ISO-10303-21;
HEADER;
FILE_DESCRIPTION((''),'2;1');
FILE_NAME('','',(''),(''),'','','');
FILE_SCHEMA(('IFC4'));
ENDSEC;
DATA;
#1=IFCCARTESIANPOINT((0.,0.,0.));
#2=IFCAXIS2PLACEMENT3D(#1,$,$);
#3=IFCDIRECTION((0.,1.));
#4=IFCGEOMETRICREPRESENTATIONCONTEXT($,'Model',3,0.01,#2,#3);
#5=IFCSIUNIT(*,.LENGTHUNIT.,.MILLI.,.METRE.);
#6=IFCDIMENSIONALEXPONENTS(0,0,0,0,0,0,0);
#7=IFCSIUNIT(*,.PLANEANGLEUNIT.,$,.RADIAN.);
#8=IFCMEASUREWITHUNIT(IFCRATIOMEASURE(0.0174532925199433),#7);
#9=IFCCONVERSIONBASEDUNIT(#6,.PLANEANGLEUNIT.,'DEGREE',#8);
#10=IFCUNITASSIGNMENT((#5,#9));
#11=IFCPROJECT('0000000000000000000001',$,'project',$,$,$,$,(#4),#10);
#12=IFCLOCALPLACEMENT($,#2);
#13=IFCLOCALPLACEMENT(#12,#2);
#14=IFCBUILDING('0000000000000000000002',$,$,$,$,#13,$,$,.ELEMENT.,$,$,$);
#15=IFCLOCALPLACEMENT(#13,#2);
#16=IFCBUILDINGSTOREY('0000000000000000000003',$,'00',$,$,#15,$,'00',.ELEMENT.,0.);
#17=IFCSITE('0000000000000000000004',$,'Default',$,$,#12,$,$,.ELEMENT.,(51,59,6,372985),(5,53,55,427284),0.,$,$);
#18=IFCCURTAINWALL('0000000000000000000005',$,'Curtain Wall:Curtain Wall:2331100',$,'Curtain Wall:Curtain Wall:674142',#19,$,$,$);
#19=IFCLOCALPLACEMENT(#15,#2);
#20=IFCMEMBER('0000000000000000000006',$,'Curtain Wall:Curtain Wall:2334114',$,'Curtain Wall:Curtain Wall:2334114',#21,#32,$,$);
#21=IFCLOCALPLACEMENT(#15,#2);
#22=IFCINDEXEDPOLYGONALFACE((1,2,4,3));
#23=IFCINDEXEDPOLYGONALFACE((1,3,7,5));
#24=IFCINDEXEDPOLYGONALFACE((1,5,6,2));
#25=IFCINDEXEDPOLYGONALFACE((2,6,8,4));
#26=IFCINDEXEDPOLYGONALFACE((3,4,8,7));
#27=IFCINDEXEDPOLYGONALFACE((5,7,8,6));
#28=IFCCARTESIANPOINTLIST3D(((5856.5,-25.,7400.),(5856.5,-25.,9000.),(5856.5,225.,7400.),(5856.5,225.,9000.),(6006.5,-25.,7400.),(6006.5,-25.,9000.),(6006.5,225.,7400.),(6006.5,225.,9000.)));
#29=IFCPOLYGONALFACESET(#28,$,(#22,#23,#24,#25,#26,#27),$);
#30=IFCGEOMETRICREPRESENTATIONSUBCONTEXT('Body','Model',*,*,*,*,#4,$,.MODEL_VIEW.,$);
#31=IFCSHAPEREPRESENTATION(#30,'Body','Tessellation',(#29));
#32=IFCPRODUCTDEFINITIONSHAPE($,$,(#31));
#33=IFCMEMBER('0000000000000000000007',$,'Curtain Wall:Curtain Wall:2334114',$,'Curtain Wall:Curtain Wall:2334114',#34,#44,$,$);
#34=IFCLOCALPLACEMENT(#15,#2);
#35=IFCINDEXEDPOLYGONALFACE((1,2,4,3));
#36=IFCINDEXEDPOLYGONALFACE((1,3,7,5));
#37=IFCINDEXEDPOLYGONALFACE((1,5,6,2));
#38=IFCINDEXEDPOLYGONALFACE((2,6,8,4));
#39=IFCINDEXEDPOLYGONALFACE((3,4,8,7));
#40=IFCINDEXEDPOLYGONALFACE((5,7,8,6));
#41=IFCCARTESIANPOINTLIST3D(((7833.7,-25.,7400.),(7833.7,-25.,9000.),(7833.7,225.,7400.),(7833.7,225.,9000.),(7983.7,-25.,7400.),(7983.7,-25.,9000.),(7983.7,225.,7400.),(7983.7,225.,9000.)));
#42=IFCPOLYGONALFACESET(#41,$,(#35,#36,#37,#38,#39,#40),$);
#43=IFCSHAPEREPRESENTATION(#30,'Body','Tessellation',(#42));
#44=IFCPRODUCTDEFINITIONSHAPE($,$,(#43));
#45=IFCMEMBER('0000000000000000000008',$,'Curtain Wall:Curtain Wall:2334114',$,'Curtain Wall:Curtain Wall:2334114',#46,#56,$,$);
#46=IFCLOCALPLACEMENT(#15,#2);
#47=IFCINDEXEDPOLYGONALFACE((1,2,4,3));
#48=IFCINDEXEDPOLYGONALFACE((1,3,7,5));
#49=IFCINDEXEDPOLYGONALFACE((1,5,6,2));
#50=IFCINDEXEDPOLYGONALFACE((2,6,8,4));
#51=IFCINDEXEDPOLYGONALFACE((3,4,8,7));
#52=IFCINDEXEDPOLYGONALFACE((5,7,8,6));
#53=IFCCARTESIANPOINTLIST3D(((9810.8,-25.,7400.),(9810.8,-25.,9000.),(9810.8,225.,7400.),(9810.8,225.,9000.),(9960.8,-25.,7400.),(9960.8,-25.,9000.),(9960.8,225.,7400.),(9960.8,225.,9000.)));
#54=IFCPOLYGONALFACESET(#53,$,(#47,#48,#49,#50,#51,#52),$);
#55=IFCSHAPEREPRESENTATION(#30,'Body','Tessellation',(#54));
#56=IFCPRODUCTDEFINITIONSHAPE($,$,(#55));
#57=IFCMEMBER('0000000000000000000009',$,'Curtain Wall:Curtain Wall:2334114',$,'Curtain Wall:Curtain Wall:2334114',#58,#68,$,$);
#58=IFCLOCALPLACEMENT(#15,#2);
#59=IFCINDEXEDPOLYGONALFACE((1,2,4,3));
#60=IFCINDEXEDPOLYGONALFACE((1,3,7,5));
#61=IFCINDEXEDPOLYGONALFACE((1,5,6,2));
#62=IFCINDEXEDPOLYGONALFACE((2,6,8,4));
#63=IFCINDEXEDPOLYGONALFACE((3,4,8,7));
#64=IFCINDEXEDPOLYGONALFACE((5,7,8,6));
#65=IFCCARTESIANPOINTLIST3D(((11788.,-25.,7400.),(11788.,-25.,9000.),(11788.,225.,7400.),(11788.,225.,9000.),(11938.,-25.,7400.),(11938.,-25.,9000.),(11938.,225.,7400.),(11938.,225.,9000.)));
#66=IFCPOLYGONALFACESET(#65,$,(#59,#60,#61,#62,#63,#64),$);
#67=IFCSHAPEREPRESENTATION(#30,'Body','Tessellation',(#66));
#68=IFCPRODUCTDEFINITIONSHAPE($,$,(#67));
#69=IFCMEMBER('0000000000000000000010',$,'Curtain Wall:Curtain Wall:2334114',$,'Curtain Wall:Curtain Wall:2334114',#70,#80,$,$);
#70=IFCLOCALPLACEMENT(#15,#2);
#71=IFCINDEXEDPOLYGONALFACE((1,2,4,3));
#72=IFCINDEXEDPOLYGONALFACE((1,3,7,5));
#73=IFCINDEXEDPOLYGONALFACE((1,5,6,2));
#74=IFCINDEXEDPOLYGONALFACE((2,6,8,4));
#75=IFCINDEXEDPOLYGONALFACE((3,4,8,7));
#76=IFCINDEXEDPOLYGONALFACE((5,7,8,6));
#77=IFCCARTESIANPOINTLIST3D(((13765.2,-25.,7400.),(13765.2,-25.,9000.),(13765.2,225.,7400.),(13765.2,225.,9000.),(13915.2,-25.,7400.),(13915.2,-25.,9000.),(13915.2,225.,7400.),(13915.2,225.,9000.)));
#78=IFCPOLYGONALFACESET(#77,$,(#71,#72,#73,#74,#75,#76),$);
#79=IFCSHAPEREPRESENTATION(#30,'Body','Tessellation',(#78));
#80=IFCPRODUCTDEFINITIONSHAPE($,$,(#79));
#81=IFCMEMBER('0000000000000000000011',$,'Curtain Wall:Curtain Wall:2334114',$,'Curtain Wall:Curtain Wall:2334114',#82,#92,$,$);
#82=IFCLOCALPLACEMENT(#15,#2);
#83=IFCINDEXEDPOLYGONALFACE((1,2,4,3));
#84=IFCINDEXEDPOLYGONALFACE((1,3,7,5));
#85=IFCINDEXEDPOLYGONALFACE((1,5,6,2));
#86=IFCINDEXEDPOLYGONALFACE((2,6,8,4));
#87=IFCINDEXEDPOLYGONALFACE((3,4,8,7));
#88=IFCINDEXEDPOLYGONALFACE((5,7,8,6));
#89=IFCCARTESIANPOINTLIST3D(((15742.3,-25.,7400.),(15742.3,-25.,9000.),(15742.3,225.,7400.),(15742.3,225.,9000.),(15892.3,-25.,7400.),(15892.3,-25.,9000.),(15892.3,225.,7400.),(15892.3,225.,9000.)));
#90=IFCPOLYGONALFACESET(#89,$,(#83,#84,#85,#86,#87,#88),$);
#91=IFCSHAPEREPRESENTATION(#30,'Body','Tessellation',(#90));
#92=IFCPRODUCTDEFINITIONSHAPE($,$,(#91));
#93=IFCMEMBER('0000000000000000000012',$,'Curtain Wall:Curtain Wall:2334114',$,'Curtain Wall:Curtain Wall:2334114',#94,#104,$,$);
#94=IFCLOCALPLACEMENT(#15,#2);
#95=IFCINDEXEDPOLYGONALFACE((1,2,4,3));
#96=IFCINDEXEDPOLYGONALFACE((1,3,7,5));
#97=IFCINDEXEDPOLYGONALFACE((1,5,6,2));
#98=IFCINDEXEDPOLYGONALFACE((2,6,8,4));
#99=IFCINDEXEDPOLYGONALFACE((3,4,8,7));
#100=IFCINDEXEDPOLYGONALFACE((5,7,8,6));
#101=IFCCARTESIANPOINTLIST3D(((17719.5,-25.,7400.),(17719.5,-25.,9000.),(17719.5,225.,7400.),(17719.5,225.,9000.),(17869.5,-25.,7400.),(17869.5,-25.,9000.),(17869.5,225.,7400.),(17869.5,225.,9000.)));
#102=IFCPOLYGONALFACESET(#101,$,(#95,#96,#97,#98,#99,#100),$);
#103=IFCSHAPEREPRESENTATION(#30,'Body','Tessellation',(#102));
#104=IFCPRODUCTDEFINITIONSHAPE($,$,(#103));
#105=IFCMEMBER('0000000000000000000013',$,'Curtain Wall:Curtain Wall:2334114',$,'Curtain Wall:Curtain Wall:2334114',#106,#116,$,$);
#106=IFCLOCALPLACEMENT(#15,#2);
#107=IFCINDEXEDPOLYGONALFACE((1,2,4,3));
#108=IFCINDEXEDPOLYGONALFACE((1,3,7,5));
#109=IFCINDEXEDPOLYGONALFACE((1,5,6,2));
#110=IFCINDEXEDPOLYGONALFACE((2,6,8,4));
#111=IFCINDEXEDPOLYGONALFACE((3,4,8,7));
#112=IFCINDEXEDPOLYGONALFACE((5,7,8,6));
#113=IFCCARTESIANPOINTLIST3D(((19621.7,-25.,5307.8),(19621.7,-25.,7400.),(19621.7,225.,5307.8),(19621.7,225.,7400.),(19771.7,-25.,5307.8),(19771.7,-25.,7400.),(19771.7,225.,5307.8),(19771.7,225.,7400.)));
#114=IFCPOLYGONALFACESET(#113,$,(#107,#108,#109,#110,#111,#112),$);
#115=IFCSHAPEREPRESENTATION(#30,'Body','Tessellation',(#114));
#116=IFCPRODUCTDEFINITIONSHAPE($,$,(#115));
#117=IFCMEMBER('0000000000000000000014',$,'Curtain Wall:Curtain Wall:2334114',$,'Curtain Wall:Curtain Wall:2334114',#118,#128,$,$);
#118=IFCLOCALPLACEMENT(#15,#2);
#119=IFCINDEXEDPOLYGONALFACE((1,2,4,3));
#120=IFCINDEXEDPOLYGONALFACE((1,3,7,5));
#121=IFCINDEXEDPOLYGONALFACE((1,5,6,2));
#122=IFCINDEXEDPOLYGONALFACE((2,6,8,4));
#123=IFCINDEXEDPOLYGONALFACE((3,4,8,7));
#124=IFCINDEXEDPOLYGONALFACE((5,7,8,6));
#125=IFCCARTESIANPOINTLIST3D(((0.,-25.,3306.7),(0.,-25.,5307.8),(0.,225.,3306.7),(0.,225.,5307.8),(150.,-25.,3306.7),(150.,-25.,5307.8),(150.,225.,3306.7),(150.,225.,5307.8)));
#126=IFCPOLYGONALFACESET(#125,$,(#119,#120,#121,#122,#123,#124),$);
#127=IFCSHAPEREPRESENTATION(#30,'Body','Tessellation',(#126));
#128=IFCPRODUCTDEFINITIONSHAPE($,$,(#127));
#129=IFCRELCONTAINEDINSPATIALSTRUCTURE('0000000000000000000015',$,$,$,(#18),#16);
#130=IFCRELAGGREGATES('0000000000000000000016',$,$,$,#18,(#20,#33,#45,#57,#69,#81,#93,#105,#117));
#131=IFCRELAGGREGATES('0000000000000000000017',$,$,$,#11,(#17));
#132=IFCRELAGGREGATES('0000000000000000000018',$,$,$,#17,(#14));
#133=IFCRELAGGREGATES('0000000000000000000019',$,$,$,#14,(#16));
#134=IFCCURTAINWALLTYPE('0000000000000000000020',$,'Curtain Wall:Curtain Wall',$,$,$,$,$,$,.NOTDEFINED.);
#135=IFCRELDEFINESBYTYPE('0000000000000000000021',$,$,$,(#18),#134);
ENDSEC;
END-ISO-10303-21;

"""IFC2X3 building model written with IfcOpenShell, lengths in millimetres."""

from ifc_helpers import new_model, entity, si_unit, converted_unit, direction, frame, frame_2d, origin, origin_2d_with_axis, place, context, subcontext, project, spatial, rectangle, extrude, type_object, element, aggregate, save


model = new_model("IFC2X3")

# Units and contexts
model_context = context("Model", 3, precision=0.01, world=origin(), true_north=direction((0.0, 1.0)))
body_context = subcontext(model_context, "Body", "Model", "MODEL_VIEW")
ifc_project = project(units=[si_unit("LENGTHUNIT", "METRE", prefix="MILLI"), converted_unit("PLANEANGLEUNIT", "DEGREE", entity("IfcRatioMeasure", 0.0174532925199433), si_unit("PLANEANGLEUNIT", "RADIAN"), dimensions=[0, 0, 0, 0, 0, 0, 0])], contexts=[model_context])

# Site, building, storey
site_placement = place(None, origin())
site = spatial("IfcSite", under=ifc_project, at=site_placement, Name="Default", CompositionType="ELEMENT", RefLatitude=(51, 59, 6, 372985), RefLongitude=(5, 53, 55, 427284), RefElevation=0.0)
building_placement = place(site_placement, origin())
building = spatial("IfcBuilding", under=site, at=building_placement, CompositionType="ELEMENT")
storey_placement = place(building_placement, origin())
storey = spatial("IfcBuildingStorey", under=building, at=storey_placement, Name="00", LongName="00", CompositionType="ELEMENT", Elevation=0.0)

# Curtain wall, members
curtain_wall_type = type_object("IfcCurtainWallType", Name="Curtain Wall:Curtain Wall", PredefinedType="NOTDEFINED")
curtain_wall_placement = place(storey_placement, origin())
curtain_wall = element("IfcCurtainWall", 1, at=curtain_wall_placement, inside=storey, type_object=curtain_wall_type, Name="Curtain Wall:Curtain Wall:2331100", ObjectType="Curtain Wall:Curtain Wall:674142")
member_1_placement = place(curtain_wall_placement, origin())
member_1 = element("IfcMember", 2, at=member_1_placement, Name="Curtain Wall:Curtain Wall:2334114", ObjectType="Curtain Wall:Curtain Wall:2334114", context=body_context, shape_type="SweptSolid", body=[
    extrude(rectangle(XDim=150.0, YDim=250.0, at=frame_2d((0.0, 0.0), x_axis=(1.0, 0.0))), frame((5931.5, 100.0, 7400.0), z_axis=(0.0, 0.0, 1.0), x_axis=(-1.0, 0.0, 0.0)), (0.0, 0.0, 1.0), 1600.0),
])
member_2_placement = place(curtain_wall_placement, origin())
member_2 = element("IfcMember", 3, at=member_2_placement, Name="Curtain Wall:Curtain Wall:2334114", ObjectType="Curtain Wall:Curtain Wall:2334114", context=body_context, shape_type="SweptSolid", body=[
    extrude(rectangle(XDim=150.0, YDim=250.0, at=frame_2d((0.0, 0.0), x_axis=(1.0, 0.0))), frame((7908.7, 100.0, 7400.0), z_axis=(0.0, 0.0, 1.0), x_axis=(-1.0, 0.0, 0.0)), (0.0, 0.0, 1.0), 1600.0),
])
member_3_placement = place(curtain_wall_placement, origin())
member_3 = element("IfcMember", 4, at=member_3_placement, Name="Curtain Wall:Curtain Wall:2334114", ObjectType="Curtain Wall:Curtain Wall:2334114", context=body_context, shape_type="SweptSolid", body=[
    extrude(rectangle(XDim=150.0, YDim=250.0, at=origin_2d_with_axis()), frame((9885.8, 100.0, 7400.0), z_axis=(0.0, 0.0, 1.0), x_axis=(-1.0, 0.0, 0.0)), (0.0, 0.0, 1.0), 1600.0),
])
member_4_placement = place(curtain_wall_placement, origin())
member_4 = element("IfcMember", 5, at=member_4_placement, Name="Curtain Wall:Curtain Wall:2334114", ObjectType="Curtain Wall:Curtain Wall:2334114", context=body_context, shape_type="SweptSolid", body=[
    extrude(rectangle(XDim=150.0, YDim=250.0, at=origin_2d_with_axis()), frame((11863.0, 100.0, 7400.0), z_axis=(0.0, 0.0, 1.0), x_axis=(-1.0, 0.0, 0.0)), (0.0, 0.0, 1.0), 1600.0),
])
member_5_placement = place(curtain_wall_placement, origin())
member_5 = element("IfcMember", 6, at=member_5_placement, Name="Curtain Wall:Curtain Wall:2334114", ObjectType="Curtain Wall:Curtain Wall:2334114", context=body_context, shape_type="SweptSolid", body=[
    extrude(rectangle(XDim=150.0, YDim=250.0, at=origin_2d_with_axis()), frame((13840.2, 100.0, 7400.0), z_axis=(0.0, 0.0, 1.0), x_axis=(-1.0, 0.0, 0.0)), (0.0, 0.0, 1.0), 1600.0),
])
member_6_placement = place(curtain_wall_placement, origin())
member_6 = element("IfcMember", 7, at=member_6_placement, Name="Curtain Wall:Curtain Wall:2334114", ObjectType="Curtain Wall:Curtain Wall:2334114", context=body_context, shape_type="SweptSolid", body=[
    extrude(rectangle(XDim=150.0, YDim=250.0, at=frame_2d((0.0, 0.0), x_axis=(1.0, 0.0))), frame((15817.3, 100.0, 7400.0), z_axis=(0.0, 0.0, 1.0), x_axis=(-1.0, 0.0, 0.0)), (0.0, 0.0, 1.0), 1600.0),
])
member_7_placement = place(curtain_wall_placement, origin())
member_7 = element("IfcMember", 8, at=member_7_placement, Name="Curtain Wall:Curtain Wall:2334114", ObjectType="Curtain Wall:Curtain Wall:2334114", context=body_context, shape_type="SweptSolid", body=[
    extrude(rectangle(XDim=150.0, YDim=250.0, at=origin_2d_with_axis()), frame((17794.5, 100.0, 7400.0), z_axis=(0.0, 0.0, 1.0), x_axis=(-1.0, 0.0, 0.0)), (0.0, 0.0, 1.0), 1600.0),
])
member_8_placement = place(curtain_wall_placement, origin())
member_8 = element("IfcMember", 9, at=member_8_placement, Name="Curtain Wall:Curtain Wall:2334114", ObjectType="Curtain Wall:Curtain Wall:2334114", context=body_context, shape_type="SweptSolid", body=[
    extrude(rectangle(XDim=150.0, YDim=250.0, at=origin_2d_with_axis()), frame((19696.7, 100.0, 5307.8), z_axis=(0.0, 0.0, 1.0), x_axis=(-1.0, 0.0, 0.0)), (0.0, 0.0, 1.0), 2092.2),
])
member_9_placement = place(curtain_wall_placement, origin())
member_9 = element("IfcMember", 10, at=member_9_placement, Name="Curtain Wall:Curtain Wall:2334114", ObjectType="Curtain Wall:Curtain Wall:2334114", context=body_context, shape_type="SweptSolid", body=[
    extrude(rectangle(XDim=150.0, YDim=250.0, at=origin_2d_with_axis()), frame((75.0, 100.0, 5307.8), z_axis=(0.0, 0.0, -1.0), x_axis=(-1.0, 0.0, 0.0)), (0.0, 0.0, 1.0), 2001.1),
])
aggregate(curtain_wall, [member_1, member_2, member_3, member_4, member_5, member_6, member_7, member_8, member_9])

save(model, "model.ifc")
